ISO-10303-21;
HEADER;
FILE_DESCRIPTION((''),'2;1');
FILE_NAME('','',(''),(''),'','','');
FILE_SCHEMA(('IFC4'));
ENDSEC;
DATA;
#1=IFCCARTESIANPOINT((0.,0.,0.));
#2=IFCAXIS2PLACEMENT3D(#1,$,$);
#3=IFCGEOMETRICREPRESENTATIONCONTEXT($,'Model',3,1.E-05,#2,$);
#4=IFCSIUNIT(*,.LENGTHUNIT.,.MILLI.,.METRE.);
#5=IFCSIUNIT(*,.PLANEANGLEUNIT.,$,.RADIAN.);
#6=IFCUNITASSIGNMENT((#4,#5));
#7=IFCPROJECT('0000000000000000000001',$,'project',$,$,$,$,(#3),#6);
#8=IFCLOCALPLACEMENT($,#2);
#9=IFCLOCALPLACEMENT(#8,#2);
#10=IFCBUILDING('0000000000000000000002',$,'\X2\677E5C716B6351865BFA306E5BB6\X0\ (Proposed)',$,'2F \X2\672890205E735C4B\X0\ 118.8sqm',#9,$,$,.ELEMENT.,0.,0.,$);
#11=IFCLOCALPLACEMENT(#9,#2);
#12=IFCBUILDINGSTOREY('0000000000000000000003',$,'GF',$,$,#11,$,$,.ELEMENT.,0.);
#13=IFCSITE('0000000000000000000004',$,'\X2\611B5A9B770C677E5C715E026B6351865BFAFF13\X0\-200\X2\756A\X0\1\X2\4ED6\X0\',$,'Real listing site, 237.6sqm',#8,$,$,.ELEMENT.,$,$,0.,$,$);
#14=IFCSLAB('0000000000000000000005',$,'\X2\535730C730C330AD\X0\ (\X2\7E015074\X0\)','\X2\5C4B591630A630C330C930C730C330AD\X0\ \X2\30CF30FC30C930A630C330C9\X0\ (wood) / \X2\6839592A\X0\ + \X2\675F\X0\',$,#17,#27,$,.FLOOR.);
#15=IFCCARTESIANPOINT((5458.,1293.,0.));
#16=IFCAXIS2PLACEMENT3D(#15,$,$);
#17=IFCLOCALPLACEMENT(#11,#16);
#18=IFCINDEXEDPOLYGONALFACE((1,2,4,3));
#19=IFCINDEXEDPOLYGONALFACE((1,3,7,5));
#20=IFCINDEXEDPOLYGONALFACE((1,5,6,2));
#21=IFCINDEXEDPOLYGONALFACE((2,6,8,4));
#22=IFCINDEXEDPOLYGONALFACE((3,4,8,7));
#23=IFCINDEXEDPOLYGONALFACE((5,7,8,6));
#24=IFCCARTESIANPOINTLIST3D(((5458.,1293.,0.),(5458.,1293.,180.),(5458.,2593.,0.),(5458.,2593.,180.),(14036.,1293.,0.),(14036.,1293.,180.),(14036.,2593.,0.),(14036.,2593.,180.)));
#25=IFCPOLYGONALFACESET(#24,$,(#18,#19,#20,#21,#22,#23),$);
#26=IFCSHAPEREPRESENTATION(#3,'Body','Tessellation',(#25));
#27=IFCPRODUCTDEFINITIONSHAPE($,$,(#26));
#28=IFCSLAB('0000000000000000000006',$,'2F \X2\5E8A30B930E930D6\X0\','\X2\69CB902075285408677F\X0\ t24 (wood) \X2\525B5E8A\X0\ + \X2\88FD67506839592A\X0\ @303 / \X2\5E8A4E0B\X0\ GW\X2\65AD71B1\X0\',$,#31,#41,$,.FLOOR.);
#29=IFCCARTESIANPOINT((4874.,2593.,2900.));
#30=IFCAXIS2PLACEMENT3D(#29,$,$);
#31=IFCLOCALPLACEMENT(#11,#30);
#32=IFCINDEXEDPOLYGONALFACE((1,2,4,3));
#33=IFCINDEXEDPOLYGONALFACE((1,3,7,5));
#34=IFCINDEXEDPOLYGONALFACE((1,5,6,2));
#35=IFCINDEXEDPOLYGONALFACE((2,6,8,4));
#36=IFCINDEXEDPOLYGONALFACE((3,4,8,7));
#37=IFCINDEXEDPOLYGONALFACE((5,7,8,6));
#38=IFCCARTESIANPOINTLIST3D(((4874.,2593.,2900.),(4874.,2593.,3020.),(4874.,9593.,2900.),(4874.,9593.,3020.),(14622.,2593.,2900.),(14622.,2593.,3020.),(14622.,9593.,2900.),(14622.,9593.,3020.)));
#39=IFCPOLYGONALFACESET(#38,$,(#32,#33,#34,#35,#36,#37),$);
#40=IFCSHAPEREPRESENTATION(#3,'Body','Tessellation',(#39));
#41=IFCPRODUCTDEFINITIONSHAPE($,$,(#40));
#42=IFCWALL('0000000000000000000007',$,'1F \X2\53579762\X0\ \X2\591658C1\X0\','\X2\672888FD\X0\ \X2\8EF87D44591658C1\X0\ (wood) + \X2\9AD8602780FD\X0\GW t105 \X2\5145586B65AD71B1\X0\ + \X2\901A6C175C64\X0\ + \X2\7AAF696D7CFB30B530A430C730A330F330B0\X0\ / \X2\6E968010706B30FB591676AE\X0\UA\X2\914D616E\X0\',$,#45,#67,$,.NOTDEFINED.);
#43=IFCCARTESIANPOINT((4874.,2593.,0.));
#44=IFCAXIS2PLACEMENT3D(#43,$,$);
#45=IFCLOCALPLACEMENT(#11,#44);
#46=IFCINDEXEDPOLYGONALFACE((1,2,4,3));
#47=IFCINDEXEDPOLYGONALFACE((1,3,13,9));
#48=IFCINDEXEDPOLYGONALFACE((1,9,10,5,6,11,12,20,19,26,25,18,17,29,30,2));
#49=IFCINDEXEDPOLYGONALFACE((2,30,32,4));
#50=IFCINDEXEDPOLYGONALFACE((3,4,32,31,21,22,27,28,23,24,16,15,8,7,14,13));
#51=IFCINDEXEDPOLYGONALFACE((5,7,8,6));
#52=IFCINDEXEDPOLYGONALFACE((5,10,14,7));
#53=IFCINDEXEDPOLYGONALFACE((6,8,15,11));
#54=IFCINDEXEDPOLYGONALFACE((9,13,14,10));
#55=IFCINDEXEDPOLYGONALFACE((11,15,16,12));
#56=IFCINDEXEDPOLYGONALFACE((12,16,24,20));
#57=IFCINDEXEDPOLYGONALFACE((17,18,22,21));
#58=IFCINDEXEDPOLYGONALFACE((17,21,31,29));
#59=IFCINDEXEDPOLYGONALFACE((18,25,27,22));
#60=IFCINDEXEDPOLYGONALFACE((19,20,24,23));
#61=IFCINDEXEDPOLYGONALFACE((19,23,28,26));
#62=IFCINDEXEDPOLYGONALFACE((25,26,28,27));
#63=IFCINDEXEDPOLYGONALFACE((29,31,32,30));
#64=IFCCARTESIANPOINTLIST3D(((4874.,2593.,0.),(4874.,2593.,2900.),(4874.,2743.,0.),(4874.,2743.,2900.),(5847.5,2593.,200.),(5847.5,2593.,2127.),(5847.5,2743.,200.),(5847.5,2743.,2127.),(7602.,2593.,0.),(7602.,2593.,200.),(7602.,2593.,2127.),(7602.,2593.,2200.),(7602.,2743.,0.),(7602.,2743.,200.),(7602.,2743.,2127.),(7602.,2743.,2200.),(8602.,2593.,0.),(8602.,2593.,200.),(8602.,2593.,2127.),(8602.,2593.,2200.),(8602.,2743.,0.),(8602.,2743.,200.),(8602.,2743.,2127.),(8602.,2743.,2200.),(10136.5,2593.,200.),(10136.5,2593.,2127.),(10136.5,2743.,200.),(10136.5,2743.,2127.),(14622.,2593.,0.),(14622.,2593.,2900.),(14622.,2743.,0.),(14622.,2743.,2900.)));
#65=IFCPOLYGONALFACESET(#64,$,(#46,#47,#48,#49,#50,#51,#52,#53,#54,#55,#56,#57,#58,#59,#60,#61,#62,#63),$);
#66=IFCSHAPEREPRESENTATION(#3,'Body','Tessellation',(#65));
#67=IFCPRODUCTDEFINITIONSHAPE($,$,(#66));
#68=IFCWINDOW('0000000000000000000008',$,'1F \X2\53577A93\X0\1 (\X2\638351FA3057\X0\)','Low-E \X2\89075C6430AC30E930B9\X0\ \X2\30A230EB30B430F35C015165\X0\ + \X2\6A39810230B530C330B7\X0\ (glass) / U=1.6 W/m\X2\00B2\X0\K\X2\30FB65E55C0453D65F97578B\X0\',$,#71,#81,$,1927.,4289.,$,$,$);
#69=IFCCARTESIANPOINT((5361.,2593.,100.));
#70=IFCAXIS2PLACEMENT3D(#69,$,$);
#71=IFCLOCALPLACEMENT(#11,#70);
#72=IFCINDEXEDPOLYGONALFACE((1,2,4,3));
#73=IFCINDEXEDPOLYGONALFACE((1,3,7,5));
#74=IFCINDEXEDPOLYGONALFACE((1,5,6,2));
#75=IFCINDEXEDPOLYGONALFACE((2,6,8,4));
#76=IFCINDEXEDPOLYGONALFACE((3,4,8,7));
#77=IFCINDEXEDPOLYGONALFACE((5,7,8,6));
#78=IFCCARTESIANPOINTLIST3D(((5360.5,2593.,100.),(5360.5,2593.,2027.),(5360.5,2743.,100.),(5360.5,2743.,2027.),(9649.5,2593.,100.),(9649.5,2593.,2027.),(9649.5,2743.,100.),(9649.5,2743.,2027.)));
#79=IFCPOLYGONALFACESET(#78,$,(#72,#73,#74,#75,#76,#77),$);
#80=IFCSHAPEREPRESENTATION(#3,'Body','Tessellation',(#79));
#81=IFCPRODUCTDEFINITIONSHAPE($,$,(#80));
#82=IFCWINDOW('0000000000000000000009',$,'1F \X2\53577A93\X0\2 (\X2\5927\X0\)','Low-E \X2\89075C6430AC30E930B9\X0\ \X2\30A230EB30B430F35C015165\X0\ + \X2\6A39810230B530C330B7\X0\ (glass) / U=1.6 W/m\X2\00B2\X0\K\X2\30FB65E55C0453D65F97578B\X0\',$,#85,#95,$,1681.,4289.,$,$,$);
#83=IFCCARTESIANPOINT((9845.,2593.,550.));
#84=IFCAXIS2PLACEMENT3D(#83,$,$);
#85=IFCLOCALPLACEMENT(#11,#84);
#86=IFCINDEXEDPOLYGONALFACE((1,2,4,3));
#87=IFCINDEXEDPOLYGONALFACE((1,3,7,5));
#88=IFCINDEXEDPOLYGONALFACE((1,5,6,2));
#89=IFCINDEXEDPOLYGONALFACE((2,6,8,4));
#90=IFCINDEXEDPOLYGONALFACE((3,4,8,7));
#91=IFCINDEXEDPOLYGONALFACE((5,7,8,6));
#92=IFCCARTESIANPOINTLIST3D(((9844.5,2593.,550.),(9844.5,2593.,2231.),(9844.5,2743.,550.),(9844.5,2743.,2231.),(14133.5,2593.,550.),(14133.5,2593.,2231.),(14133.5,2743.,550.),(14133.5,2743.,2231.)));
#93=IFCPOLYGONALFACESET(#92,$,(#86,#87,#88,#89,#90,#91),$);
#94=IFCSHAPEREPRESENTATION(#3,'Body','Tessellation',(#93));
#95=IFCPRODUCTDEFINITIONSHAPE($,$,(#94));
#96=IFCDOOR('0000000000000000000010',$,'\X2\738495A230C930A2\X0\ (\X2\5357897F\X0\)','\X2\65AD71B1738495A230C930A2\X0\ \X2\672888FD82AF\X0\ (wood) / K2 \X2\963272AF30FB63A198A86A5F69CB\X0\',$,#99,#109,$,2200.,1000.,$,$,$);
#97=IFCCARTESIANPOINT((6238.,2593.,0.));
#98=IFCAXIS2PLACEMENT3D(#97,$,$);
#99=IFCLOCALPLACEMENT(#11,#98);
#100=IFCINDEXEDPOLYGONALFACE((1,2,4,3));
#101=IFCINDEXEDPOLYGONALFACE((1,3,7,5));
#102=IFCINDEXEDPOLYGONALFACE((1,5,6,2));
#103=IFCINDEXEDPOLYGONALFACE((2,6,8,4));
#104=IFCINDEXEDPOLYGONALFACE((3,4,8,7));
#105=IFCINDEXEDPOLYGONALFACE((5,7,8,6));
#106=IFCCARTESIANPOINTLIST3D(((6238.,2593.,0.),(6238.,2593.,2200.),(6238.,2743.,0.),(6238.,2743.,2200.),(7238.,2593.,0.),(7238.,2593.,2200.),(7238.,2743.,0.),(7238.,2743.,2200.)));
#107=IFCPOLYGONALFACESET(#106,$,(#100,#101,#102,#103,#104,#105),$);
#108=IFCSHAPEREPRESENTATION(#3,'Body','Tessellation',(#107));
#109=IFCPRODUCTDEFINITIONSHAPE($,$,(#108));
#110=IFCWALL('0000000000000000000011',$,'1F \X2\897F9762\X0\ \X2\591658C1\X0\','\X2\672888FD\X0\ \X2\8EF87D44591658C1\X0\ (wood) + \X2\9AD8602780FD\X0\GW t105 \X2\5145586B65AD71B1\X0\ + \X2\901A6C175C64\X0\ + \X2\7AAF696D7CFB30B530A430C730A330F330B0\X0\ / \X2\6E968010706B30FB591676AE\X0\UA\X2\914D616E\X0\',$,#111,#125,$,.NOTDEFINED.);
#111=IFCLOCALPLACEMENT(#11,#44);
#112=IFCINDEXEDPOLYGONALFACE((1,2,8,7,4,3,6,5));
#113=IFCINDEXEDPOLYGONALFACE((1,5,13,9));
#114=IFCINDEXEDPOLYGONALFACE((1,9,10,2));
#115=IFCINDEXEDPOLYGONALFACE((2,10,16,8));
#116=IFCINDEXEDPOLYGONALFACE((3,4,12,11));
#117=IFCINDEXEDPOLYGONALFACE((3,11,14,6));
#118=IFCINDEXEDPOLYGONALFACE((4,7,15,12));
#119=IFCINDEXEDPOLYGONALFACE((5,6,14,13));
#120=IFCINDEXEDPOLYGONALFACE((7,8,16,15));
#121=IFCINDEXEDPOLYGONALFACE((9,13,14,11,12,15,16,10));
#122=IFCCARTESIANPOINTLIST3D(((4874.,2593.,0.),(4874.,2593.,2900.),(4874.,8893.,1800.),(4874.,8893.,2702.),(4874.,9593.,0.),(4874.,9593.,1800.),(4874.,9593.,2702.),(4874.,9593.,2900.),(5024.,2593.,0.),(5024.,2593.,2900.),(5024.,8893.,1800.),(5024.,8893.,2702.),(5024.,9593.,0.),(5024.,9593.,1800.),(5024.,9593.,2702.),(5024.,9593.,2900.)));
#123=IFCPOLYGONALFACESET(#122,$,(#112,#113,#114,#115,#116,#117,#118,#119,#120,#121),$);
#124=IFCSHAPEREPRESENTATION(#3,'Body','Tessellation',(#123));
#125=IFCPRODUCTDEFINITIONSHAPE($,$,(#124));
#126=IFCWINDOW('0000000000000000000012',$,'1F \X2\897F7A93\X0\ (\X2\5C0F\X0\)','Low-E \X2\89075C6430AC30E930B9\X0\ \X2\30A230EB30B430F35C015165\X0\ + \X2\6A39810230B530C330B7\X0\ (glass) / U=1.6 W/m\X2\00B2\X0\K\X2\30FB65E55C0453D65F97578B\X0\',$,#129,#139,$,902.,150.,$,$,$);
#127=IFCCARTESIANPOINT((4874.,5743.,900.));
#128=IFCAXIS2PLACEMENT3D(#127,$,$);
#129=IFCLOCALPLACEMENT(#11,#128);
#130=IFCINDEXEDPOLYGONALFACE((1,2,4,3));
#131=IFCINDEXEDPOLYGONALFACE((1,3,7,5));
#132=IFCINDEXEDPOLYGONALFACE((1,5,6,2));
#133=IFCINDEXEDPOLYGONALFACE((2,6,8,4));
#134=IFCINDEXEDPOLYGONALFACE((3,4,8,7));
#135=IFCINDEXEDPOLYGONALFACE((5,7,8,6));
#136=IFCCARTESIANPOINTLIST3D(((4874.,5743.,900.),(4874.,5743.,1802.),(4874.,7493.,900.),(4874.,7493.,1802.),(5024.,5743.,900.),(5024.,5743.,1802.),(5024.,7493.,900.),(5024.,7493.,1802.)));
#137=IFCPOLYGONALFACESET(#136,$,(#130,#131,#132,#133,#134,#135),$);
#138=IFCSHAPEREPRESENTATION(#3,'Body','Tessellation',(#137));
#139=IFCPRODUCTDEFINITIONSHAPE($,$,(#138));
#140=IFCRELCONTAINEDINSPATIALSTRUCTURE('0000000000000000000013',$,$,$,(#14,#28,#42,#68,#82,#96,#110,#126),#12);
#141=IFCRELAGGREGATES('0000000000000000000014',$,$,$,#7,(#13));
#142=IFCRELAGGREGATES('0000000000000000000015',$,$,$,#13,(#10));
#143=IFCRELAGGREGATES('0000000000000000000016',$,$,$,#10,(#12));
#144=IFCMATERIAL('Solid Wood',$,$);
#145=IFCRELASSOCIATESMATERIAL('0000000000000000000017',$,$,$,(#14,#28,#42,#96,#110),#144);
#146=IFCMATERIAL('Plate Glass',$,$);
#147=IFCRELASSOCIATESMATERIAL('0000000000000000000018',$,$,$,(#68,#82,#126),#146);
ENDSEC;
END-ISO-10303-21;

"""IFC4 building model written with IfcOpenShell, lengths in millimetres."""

from ifc_helpers import new_model, si_unit, frame, frame_2d, origin, place, context, project, spatial, rectangle, extrude, material, element, fill, save


model = new_model("IFC4")

# Units and contexts
model_context = context("Model", 3, precision=1e-05, world=origin())
ifc_project = project(units=[si_unit("LENGTHUNIT", "METRE", prefix="MILLI"), si_unit("PLANEANGLEUNIT", "RADIAN")], contexts=[model_context])

# Site, building, storey
site_placement = place(None, origin())
site = spatial("IfcSite", under=ifc_project, at=site_placement, Name="愛媛県松山市正円寺３-200番1他", ObjectType="Real listing site, 237.6sqm", CompositionType="ELEMENT", RefElevation=0.0)
building_placement = place(site_placement, origin())
building = spatial("IfcBuilding", under=site, at=building_placement, Name="松山正円寺の家 (Proposed)", ObjectType="2F 木造平屋 118.8sqm", CompositionType="ELEMENT", ElevationOfRefHeight=0.0, ElevationOfTerrain=0.0)
storey_placement = place(building_placement, origin())
storey = spatial("IfcBuildingStorey", under=building, at=storey_placement, Name="GF", CompositionType="ELEMENT", Elevation=0.0)

# Slabs
ifc_material_1 = material(Name="Solid Wood")
slab_1_placement = place(storey_placement, frame((5458.0, 1293.0, 0.0)))
element("IfcSlab", 1, at=slab_1_placement, inside=storey, material=ifc_material_1, Name="南デッキ (縁側)", Description="屋外ウッドデッキ ハードウッド (wood) / 根太 + 束", PredefinedType="FLOOR", context=model_context, shape_type="SweptSolid", body=[
    extrude(rectangle(XDim=8578.0, YDim=1300.0, at=frame_2d((4289.0, 650.0))), frame((5458.0, 1293.0, 0.0)), (0.0, 0.0, 1.0), 180.0),
])
slab_2_placement = place(storey_placement, frame((4874.0, 2593.0, 2900.0)))
element("IfcSlab", 2, at=slab_2_placement, inside=storey, material=ifc_material_1, Name="2F 床スラブ", Description="構造用合板 t24 (wood) 剛床 + 製材根太 @303 / 床下 GW断熱", PredefinedType="FLOOR", context=model_context, shape_type="SweptSolid", body=[
    extrude(rectangle(XDim=9748.0, YDim=7000.0, at=frame_2d((4874.0, 3500.0))), frame((4874.0, 2593.0, 2900.0)), (0.0, 0.0, 1.0), 120.0),
])

# Wall, openings, windows, door
wall_1_placement = place(storey_placement, frame((4874.0, 2593.0, 0.0)))
wall_1 = element("IfcWall", 3, at=wall_1_placement, inside=storey, material=ifc_material_1, Name="1F 南面 外壁", Description="木製 軸組外壁 (wood) + 高性能GW t105 充填断熱 + 通気層 + 窯業系サイディング / 準耐火・外皮UA配慮", PredefinedType="NOTDEFINED", context=model_context, shape_type="SweptSolid", body=[
    extrude(rectangle(XDim=9748.0, YDim=150.0, at=frame_2d((4874.0, 75.0))), frame((4874.0, 2593.0, 0.0)), (0.0, 0.0, 1.0), 2900.0),
])
opening_1_placement = place(storey_placement, frame((5361.0, 2593.0, 100.0)))
opening_1 = element("IfcOpeningElement", 4, at=opening_1_placement, cuts=wall_1, PredefinedType="NOTDEFINED", context=model_context, shape_type="SweptSolid", body=[
    extrude(rectangle(XDim=4289.0, YDim=150.0, at=frame_2d((2144.0, 75.0))), frame((5361.0, 2593.0, 100.0)), (0.0, 0.0, 1.0), 1927.0),
])
opening_2_placement = place(storey_placement, frame((9845.0, 2593.0, 550.0)))
opening_2 = element("IfcOpeningElement", 5, at=opening_2_placement, cuts=wall_1, PredefinedType="NOTDEFINED", context=model_context, shape_type="SweptSolid", body=[
    extrude(rectangle(XDim=4289.0, YDim=150.0, at=frame_2d((2144.0, 75.0))), frame((9845.0, 2593.0, 550.0)), (0.0, 0.0, 1.0), 1681.0),
])
opening_3_placement = place(storey_placement, frame((6238.0, 2593.0, 0.0)))
opening_3 = element("IfcOpeningElement", 6, at=opening_3_placement, cuts=wall_1, PredefinedType="NOTDEFINED", context=model_context, shape_type="SweptSolid", body=[
    extrude(rectangle(XDim=1000.0, YDim=150.0, at=frame_2d((500.0, 75.0))), frame((6238.0, 2593.0, 0.0)), (0.0, 0.0, 1.0), 2200.0),
])
ifc_material_2 = material(Name="Plate Glass")
window_1_placement = place(storey_placement, frame((5361.0, 2593.0, 100.0)))
window_1 = element("IfcWindow", 7, at=window_1_placement, inside=storey, material=ifc_material_2, Name="1F 南窓1 (掃出し)", Description="Low-E 複層ガラス アルゴン封入 + 樹脂サッシ (glass) / U=1.6 W/m²K・日射取得型", OverallHeight=1927.0, OverallWidth=4289.0, context=model_context, shape_type="SweptSolid", body=[
    extrude(rectangle(XDim=4289.0, YDim=150.0, at=frame_2d((2144.0, 75.0))), frame((5361.0, 2593.0, 100.0)), (0.0, 0.0, 1.0), 1927.0),
])
fill(opening_1, window_1)
window_2_placement = place(storey_placement, frame((9845.0, 2593.0, 550.0)))
window_2 = element("IfcWindow", 8, at=window_2_placement, inside=storey, material=ifc_material_2, Name="1F 南窓2 (大)", Description="Low-E 複層ガラス アルゴン封入 + 樹脂サッシ (glass) / U=1.6 W/m²K・日射取得型", OverallHeight=1681.0, OverallWidth=4289.0, context=model_context, shape_type="SweptSolid", body=[
    extrude(rectangle(XDim=4289.0, YDim=150.0, at=frame_2d((2144.0, 75.0))), frame((9845.0, 2593.0, 550.0)), (0.0, 0.0, 1.0), 1681.0),
])
fill(opening_2, window_2)
door_placement = place(storey_placement, frame((6238.0, 2593.0, 0.0)))
door = element("IfcDoor", 9, at=door_placement, inside=storey, material=ifc_material_1, Name="玄関ドア (南西)", Description="断熱玄関ドア 木製芯 (wood) / K2 防犯・採風機構", OverallHeight=2200.0, OverallWidth=1000.0, context=model_context, shape_type="SweptSolid", body=[
    extrude(rectangle(XDim=1000.0, YDim=150.0, at=frame_2d((500.0, 75.0))), frame((6238.0, 2593.0, 0.0)), (0.0, 0.0, 1.0), 2200.0),
])
fill(opening_3, door)

# Wall, opening, window
wall_2_placement = place(storey_placement, frame((4874.0, 2593.0, 0.0)))
wall_2 = element("IfcWall", 10, at=wall_2_placement, inside=storey, material=ifc_material_1, Name="1F 西面 外壁", Description="木製 軸組外壁 (wood) + 高性能GW t105 充填断熱 + 通気層 + 窯業系サイディング / 準耐火・外皮UA配慮", PredefinedType="NOTDEFINED", context=model_context, shape_type="SweptSolid", body=[
    extrude(rectangle(XDim=150.0, YDim=7000.0, at=frame_2d((75.0, 3500.0))), frame((4874.0, 2593.0, 0.0)), (0.0, 0.0, 1.0), 2900.0),
])
opening_4_placement = place(storey_placement, frame((4874.0, 5743.0, 900.0)))
opening_4 = element("IfcOpeningElement", 11, at=opening_4_placement, cuts=wall_2, PredefinedType="NOTDEFINED", context=model_context, shape_type="SweptSolid", body=[
    extrude(rectangle(XDim=150.0, YDim=1750.0, at=frame_2d((75.0, 875.0))), frame((4874.0, 5743.0, 900.0)), (0.0, 0.0, 1.0), 902.0),
])
window_3_placement = place(storey_placement, frame((4874.0, 5743.0, 900.0)))
window_3 = element("IfcWindow", 12, at=window_3_placement, inside=storey, material=ifc_material_2, Name="1F 西窓 (小)", Description="Low-E 複層ガラス アルゴン封入 + 樹脂サッシ (glass) / U=1.6 W/m²K・日射取得型", OverallHeight=902.0, OverallWidth=150.0, context=model_context, shape_type="SweptSolid", body=[
    extrude(rectangle(XDim=150.0, YDim=1750.0, at=frame_2d((75.0, 875.0))), frame((4874.0, 5743.0, 900.0)), (0.0, 0.0, 1.0), 902.0),
])
fill(opening_4, window_3)

save(model, "model.ifc")
